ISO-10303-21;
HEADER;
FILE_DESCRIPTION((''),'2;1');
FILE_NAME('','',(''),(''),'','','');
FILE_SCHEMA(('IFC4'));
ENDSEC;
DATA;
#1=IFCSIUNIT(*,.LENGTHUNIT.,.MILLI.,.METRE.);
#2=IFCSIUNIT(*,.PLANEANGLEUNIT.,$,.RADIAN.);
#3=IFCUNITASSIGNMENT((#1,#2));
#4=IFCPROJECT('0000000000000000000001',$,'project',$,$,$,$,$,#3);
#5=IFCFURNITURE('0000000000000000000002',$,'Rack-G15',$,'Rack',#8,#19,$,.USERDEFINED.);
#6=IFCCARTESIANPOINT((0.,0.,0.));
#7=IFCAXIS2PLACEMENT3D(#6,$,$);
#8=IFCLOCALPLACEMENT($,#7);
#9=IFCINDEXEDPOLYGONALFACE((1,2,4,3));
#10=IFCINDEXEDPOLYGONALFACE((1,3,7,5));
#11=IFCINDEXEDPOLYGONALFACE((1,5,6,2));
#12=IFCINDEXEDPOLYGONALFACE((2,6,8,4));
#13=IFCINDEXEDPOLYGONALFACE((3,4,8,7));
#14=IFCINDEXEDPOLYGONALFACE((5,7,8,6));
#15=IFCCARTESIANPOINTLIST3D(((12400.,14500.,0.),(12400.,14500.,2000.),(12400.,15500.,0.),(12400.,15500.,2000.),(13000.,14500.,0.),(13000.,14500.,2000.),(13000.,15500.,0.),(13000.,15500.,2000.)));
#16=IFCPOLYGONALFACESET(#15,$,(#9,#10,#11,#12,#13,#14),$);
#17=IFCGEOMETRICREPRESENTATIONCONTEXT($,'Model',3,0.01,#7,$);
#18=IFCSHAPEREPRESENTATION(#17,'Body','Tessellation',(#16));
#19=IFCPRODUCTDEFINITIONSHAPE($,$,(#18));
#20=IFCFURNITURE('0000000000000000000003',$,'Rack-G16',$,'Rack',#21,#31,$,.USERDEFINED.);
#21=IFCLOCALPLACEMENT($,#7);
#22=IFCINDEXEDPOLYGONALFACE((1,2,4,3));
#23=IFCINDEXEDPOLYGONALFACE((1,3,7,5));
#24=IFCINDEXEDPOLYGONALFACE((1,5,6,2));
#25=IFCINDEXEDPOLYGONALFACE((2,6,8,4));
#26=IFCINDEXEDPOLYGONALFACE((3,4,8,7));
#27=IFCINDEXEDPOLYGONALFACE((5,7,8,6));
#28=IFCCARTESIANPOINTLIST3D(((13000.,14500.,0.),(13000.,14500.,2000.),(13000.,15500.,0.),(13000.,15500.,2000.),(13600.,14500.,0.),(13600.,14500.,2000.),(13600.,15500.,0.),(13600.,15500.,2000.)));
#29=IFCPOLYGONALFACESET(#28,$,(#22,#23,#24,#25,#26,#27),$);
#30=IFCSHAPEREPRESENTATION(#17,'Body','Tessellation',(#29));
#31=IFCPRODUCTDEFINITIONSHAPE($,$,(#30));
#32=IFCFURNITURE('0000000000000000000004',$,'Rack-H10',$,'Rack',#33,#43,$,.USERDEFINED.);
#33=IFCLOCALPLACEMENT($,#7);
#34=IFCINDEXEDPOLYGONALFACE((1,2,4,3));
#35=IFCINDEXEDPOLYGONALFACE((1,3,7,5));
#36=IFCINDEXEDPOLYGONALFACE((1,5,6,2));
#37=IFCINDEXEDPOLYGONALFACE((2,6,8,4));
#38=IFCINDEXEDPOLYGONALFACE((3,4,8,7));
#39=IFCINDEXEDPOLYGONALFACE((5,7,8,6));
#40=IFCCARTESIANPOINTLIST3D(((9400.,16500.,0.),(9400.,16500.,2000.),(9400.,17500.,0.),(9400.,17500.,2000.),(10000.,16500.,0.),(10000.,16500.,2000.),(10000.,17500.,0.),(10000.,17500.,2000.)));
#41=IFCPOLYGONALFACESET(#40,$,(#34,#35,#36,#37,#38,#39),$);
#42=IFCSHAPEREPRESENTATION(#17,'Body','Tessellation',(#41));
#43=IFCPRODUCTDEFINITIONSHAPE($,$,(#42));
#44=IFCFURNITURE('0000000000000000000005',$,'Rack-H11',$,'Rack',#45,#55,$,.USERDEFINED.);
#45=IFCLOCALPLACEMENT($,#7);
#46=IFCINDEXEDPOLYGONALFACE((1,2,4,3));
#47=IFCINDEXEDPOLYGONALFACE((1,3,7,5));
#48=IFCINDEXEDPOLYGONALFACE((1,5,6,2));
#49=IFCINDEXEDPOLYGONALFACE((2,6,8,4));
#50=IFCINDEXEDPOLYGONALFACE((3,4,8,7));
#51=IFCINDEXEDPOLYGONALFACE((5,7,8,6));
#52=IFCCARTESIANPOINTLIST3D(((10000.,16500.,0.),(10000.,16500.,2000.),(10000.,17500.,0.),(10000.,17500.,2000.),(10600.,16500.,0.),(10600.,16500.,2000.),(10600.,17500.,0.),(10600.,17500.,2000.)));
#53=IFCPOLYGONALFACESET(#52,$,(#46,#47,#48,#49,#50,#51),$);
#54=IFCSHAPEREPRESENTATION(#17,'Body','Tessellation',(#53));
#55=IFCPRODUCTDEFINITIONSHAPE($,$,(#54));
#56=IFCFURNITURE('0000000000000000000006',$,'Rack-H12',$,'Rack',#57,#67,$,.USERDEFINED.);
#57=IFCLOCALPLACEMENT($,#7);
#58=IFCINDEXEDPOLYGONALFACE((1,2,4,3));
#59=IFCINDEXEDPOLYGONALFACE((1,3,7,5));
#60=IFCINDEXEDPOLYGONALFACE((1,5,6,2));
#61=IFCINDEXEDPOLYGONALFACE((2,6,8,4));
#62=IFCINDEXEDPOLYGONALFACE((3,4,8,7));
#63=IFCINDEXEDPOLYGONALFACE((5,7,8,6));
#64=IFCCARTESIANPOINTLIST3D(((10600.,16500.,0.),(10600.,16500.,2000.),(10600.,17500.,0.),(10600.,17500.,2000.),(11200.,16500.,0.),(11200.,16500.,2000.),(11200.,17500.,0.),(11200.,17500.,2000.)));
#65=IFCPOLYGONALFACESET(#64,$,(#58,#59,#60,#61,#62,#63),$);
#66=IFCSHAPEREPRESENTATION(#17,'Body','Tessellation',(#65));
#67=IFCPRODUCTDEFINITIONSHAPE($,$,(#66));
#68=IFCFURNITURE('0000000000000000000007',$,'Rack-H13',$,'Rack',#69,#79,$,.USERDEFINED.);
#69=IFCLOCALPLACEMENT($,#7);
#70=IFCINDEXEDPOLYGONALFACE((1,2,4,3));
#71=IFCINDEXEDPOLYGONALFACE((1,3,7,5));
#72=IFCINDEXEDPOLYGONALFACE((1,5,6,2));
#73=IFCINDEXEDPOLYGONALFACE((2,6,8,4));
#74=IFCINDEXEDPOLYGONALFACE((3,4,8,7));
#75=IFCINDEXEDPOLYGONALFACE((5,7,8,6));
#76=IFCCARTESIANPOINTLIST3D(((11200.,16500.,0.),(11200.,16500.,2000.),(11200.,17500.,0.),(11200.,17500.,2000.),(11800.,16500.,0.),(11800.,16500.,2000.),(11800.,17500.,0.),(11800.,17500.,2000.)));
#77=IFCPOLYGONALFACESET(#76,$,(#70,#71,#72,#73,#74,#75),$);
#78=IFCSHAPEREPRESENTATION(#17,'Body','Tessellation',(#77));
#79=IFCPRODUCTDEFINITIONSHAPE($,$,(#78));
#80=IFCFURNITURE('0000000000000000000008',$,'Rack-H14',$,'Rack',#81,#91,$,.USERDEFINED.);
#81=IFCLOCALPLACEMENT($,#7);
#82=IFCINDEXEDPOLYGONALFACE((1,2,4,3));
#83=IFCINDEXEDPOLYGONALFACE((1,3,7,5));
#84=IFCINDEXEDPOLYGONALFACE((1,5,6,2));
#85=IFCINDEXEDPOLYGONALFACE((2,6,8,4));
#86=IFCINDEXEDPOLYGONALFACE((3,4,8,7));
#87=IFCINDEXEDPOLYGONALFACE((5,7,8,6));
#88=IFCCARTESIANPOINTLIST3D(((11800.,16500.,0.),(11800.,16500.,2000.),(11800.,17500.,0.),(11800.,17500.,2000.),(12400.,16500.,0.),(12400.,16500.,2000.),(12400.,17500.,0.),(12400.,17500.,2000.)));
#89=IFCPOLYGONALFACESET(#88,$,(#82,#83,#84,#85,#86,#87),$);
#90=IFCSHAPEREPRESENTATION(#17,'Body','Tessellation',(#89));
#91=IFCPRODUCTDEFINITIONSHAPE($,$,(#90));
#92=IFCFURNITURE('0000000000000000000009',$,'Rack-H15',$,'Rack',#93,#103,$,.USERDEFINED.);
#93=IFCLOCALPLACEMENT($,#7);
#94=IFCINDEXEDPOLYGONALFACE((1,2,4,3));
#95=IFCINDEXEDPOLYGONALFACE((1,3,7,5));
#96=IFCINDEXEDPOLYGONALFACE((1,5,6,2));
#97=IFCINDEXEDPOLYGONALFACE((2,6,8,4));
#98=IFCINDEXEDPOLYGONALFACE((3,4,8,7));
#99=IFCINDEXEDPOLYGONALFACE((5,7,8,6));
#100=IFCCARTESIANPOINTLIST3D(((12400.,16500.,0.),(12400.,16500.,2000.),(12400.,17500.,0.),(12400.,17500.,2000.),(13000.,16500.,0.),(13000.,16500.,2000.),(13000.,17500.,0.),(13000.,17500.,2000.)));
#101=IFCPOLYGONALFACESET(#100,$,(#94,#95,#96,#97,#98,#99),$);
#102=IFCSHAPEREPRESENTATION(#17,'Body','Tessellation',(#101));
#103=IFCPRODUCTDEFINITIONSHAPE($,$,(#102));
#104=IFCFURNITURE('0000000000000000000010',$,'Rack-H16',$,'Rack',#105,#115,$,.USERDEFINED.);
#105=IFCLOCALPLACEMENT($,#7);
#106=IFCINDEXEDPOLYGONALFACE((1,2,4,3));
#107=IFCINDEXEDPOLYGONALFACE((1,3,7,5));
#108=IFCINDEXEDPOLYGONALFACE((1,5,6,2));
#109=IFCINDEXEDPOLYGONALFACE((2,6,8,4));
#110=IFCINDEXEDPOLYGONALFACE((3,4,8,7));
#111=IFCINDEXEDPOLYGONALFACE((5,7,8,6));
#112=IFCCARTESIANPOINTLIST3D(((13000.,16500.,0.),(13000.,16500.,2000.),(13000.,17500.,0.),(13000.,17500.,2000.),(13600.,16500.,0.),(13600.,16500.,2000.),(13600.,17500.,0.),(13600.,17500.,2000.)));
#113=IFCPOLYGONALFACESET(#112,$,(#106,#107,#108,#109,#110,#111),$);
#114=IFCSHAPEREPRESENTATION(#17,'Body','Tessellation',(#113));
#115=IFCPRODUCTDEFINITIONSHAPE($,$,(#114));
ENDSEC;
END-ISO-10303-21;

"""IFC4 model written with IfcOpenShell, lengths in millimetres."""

from ifc_helpers import new_model, si_unit, frame, origin, place, context, project, polyline, outline, extrude, element, save


model = new_model("IFC4")

# Units and contexts
model_context = context("Model", 3, precision=0.01, world=origin())
ifc_project = project(units=[si_unit("LENGTHUNIT", "METRE", prefix="MILLI"), si_unit("PLANEANGLEUNIT", "RADIAN")])

# Furniture
for number, where, name in (
    (1, (12700.0, 15000.0, 0.0), "Rack-G15"),
    (2, (13300.0, 15000.0, 0.0), "Rack-G16"),
    (3, (9700.0, 17000.0, 0.0), "Rack-H10"),
    (4, (10300.0, 17000.0, 0.0), "Rack-H11"),
    (5, (10900.0, 17000.0, 0.0), "Rack-H12"),
    (6, (11500.0, 17000.0, 0.0), "Rack-H13"),
    (7, (12100.0, 17000.0, 0.0), "Rack-H14"),
    (8, (12700.0, 17000.0, 0.0), "Rack-H15"),
    (9, (13300.0, 17000.0, 0.0), "Rack-H16"),
):
    element("IfcFurniture", number, at=place(None, frame(where)), Name=name, ObjectType="Rack", PredefinedType="USERDEFINED", context=model_context, shape_type="SweptSolid", body=[
        extrude(outline(polyline([(-300.0, -500.0), (300.0, -500.0), (300.0, 500.0), (-300.0, 500.0), (-300.0, -500.0)])), origin(), (0.0, 0.0, 1.0), 2000.0),
    ])

save(model, "model.ifc")
